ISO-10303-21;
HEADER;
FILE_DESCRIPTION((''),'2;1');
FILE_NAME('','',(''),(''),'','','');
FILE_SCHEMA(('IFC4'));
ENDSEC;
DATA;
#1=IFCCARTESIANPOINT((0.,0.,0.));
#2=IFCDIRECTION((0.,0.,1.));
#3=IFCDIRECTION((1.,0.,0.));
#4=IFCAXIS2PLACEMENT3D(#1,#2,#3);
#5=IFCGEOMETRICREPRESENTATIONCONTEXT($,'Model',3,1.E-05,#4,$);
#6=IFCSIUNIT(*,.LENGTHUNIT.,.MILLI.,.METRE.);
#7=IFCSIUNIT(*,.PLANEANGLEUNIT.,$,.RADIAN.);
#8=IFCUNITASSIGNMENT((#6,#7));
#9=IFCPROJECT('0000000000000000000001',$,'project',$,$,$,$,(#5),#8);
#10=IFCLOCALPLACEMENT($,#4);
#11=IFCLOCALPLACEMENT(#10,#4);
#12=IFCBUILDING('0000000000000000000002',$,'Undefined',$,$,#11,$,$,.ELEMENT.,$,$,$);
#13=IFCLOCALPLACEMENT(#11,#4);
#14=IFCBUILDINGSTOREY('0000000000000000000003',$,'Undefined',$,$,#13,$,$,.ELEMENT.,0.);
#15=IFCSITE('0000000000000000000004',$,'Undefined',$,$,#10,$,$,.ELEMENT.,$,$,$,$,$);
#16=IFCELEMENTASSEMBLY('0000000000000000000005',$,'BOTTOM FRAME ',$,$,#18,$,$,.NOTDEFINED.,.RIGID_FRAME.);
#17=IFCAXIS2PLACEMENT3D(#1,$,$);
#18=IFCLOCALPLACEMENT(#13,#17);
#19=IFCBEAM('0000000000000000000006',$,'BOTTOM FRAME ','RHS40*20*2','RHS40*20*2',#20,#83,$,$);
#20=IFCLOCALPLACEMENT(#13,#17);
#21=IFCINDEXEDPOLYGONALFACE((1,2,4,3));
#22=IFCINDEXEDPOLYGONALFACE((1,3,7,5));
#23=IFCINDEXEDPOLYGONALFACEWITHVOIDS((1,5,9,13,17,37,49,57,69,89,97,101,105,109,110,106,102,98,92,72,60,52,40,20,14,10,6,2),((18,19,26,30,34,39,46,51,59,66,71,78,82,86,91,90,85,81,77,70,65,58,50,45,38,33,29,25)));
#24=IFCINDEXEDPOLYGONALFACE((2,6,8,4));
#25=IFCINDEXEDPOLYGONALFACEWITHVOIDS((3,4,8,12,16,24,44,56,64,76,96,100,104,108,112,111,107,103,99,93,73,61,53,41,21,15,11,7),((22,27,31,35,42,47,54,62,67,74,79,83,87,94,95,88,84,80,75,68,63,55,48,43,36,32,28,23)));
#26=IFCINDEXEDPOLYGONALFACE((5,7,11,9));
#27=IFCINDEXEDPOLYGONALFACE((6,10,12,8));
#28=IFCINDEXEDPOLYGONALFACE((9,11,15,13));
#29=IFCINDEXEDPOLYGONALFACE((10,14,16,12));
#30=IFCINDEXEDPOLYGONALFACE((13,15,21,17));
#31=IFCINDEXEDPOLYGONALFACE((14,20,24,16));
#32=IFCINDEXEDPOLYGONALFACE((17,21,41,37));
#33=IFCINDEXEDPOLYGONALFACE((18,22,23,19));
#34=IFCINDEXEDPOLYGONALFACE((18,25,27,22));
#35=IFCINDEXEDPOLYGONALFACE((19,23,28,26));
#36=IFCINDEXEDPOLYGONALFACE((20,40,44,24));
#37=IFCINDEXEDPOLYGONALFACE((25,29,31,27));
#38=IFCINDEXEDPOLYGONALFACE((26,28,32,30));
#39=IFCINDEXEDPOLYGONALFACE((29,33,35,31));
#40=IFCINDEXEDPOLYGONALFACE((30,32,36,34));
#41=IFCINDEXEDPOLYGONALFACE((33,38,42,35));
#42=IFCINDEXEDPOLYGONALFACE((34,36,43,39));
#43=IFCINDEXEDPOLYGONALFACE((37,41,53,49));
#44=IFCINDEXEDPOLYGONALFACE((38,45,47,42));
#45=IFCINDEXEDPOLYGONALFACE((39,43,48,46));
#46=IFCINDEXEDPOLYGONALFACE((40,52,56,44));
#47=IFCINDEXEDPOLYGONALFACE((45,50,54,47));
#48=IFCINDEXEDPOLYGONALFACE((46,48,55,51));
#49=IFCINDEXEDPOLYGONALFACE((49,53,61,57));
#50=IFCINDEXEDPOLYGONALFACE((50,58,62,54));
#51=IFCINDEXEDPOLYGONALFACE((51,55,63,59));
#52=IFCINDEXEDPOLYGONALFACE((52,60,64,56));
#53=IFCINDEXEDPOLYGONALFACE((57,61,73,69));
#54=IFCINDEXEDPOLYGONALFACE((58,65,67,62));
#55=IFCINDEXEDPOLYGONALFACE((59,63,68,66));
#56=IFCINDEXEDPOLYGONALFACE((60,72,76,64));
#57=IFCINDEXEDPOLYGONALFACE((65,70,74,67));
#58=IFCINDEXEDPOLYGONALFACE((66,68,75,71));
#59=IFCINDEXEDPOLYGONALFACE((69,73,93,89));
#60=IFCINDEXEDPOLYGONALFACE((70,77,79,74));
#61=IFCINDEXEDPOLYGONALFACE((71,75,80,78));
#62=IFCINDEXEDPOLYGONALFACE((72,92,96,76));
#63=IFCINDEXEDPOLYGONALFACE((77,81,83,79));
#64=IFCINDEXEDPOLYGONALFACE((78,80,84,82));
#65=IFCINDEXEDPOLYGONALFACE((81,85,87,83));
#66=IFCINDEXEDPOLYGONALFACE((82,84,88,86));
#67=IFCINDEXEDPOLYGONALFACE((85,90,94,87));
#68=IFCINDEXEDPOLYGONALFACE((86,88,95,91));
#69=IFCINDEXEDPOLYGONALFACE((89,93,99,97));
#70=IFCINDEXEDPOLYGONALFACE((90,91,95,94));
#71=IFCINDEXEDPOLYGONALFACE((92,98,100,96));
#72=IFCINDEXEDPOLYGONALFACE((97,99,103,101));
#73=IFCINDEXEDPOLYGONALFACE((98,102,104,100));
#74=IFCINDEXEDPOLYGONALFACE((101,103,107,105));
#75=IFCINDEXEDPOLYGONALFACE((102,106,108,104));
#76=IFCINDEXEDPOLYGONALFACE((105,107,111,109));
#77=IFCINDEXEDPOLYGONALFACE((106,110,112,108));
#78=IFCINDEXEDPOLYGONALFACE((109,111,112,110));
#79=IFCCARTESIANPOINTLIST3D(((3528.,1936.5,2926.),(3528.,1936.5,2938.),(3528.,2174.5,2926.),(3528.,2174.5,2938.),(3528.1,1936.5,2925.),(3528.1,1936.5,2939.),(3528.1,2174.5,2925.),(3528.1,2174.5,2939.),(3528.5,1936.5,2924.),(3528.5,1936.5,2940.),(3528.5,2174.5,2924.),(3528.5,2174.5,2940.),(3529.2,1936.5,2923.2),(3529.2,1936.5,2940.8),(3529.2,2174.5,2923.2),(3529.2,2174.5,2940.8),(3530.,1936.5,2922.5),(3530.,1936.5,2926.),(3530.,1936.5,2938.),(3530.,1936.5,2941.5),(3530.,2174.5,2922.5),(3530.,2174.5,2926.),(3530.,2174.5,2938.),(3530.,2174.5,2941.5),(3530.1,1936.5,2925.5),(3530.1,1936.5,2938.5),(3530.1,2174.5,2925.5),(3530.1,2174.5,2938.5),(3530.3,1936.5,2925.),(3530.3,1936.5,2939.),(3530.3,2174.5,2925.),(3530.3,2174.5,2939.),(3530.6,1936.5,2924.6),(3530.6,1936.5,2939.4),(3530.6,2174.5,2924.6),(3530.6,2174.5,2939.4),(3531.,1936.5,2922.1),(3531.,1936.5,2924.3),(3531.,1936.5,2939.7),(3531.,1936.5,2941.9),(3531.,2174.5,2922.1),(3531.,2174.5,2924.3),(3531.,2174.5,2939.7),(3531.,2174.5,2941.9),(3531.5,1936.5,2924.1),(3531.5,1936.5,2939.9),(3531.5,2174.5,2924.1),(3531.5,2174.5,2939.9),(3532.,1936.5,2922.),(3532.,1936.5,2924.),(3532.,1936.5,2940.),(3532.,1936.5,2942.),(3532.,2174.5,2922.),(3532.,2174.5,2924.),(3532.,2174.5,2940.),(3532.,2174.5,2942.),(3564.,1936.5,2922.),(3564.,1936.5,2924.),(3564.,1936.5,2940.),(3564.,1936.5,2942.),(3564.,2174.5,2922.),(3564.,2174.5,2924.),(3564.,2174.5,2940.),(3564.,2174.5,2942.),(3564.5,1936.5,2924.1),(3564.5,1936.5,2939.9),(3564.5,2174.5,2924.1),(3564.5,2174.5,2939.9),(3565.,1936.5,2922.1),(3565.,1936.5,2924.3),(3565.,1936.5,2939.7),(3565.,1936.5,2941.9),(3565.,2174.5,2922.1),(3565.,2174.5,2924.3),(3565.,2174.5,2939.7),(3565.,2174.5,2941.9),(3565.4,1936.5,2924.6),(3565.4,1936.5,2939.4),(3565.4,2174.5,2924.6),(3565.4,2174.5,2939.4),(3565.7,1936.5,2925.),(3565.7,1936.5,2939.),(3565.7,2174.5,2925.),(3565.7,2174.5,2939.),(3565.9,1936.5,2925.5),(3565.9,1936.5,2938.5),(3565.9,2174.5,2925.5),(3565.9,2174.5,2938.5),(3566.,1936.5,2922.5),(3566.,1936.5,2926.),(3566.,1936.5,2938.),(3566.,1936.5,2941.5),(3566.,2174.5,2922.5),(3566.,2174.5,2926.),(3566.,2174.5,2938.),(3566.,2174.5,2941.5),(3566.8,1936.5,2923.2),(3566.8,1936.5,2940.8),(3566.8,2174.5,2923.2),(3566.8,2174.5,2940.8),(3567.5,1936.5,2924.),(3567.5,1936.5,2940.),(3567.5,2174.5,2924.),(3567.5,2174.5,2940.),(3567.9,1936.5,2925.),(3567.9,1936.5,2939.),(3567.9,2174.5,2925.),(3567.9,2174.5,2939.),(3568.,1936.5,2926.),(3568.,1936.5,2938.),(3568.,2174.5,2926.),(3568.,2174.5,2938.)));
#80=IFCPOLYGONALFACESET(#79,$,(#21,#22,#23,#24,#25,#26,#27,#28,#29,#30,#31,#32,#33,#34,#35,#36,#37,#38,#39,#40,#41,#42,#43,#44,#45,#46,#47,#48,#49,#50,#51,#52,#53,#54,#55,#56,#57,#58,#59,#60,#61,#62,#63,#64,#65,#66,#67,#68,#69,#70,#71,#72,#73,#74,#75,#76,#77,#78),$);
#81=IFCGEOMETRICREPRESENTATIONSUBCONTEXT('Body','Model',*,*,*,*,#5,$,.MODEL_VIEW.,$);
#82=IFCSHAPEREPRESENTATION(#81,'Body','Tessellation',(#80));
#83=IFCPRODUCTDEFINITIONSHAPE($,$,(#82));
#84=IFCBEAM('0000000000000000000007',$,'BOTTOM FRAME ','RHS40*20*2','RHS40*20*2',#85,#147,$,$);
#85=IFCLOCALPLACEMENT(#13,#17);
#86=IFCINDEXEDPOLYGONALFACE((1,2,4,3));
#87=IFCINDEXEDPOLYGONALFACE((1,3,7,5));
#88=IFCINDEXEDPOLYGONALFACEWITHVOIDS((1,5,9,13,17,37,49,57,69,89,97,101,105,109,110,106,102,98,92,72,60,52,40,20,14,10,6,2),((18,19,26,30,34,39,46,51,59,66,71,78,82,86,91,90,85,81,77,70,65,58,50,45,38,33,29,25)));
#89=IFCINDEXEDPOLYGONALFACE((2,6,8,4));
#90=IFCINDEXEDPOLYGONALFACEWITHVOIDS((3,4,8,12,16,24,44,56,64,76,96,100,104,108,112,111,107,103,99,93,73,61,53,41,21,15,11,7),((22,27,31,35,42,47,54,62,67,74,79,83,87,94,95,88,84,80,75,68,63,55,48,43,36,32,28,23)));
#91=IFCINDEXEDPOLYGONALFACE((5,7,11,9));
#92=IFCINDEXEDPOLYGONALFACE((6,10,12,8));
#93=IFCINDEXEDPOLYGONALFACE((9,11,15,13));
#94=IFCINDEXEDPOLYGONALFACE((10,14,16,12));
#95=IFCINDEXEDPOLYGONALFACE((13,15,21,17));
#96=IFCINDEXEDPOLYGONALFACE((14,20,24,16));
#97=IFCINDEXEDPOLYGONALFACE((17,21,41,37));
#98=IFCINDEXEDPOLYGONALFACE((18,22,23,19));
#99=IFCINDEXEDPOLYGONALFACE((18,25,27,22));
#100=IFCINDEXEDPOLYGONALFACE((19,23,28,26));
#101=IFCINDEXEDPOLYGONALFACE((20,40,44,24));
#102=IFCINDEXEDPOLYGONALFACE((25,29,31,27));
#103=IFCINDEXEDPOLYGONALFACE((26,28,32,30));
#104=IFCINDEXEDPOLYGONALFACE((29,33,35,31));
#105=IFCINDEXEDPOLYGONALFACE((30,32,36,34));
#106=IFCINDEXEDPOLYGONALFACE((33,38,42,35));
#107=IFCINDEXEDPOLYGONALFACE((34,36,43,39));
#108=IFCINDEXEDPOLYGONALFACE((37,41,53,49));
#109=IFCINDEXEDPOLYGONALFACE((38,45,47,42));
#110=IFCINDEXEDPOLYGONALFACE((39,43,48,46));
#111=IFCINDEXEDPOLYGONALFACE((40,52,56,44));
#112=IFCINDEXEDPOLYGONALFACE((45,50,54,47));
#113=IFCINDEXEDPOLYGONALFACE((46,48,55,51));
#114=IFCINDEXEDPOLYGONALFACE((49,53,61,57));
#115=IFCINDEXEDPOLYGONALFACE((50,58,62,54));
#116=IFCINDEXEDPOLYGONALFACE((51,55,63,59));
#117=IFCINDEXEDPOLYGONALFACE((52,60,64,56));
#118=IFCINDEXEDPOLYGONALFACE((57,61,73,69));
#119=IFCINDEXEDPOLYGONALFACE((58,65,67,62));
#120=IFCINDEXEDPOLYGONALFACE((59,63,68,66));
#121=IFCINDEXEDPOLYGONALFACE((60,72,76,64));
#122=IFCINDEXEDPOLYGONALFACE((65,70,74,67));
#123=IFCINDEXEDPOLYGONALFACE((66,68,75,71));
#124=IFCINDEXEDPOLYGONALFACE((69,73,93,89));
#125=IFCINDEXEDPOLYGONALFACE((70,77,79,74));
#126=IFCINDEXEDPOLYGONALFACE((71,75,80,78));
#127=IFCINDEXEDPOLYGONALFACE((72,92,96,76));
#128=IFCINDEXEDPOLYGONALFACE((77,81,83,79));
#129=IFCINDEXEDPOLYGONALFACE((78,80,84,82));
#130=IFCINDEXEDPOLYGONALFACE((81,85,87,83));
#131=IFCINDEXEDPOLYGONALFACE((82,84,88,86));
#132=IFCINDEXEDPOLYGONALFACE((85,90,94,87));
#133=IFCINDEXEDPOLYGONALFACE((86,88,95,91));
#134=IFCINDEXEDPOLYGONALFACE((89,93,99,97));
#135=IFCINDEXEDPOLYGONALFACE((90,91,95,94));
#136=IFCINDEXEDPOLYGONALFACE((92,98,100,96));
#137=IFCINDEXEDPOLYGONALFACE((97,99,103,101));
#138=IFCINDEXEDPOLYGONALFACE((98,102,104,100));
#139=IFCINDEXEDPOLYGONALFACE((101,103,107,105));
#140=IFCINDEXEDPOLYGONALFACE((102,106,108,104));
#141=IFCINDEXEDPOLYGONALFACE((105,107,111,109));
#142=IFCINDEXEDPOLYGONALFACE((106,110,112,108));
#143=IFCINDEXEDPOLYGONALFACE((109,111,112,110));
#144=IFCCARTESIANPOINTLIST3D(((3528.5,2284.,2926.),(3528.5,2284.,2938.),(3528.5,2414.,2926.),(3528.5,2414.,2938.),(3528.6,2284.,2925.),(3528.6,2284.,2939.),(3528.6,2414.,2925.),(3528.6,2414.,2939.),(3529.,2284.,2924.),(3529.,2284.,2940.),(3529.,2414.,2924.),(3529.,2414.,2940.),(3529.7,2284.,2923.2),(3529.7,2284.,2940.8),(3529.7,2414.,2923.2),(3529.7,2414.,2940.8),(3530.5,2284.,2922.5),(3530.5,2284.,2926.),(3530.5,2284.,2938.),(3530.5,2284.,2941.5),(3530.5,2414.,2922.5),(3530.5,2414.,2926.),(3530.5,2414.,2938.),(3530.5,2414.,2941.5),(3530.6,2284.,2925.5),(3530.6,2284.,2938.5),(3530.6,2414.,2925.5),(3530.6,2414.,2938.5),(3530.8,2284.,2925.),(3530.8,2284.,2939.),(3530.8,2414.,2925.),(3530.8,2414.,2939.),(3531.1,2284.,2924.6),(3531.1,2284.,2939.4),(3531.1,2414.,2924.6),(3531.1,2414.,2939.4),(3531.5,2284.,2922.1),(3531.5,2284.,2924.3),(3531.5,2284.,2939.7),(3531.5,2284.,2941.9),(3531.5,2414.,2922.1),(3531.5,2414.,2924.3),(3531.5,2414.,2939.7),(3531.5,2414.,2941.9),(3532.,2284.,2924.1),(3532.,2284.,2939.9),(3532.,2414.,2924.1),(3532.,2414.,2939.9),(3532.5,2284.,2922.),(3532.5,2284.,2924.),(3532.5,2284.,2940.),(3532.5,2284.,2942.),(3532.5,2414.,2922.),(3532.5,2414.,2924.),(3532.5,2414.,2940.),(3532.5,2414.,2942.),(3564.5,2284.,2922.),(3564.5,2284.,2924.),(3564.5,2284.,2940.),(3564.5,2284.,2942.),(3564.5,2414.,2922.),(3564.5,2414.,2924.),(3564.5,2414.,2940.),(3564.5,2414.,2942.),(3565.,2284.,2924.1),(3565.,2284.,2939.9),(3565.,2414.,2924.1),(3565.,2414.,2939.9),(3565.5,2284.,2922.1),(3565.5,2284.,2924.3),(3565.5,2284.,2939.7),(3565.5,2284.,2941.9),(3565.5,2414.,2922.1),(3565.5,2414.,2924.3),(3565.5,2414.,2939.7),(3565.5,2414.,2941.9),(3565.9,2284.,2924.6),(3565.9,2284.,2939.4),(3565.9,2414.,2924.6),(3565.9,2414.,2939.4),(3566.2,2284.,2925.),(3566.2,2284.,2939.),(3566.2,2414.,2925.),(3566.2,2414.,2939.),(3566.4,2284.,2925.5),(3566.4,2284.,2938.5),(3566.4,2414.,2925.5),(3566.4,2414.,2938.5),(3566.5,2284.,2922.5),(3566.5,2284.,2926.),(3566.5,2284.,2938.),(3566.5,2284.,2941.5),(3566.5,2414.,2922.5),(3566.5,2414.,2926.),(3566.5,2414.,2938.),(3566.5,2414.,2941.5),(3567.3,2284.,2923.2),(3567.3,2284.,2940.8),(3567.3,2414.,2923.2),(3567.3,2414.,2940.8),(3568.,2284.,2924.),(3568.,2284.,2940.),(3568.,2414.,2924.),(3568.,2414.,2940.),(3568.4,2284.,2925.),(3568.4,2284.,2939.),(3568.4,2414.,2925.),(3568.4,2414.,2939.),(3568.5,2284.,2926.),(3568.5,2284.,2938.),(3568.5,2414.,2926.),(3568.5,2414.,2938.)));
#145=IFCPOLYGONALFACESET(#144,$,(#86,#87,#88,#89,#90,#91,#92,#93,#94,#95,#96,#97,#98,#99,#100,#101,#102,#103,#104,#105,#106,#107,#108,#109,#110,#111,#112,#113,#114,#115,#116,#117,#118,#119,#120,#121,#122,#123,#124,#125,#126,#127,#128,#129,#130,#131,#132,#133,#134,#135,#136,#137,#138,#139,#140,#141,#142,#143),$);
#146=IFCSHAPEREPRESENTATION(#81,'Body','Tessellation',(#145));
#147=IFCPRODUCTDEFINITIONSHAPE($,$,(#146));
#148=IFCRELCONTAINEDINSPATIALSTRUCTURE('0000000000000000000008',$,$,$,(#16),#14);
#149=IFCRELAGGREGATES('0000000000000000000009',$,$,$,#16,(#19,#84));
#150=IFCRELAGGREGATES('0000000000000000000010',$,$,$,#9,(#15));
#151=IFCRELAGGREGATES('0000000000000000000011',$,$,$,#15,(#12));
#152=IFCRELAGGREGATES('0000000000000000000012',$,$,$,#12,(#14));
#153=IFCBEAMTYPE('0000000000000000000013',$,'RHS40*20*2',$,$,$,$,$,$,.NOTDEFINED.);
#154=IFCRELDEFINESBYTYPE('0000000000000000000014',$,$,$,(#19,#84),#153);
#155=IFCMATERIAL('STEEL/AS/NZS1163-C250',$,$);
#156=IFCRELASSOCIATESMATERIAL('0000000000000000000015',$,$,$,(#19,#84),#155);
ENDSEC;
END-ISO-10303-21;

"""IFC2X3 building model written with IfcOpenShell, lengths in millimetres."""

from ifc_helpers import new_model, si_unit, frame, origin_with_axes, origin_2d_with_axis, place, context, subcontext, project, spatial, hollow_rectangle, extrude, material, type_object, element, aggregate, save


model = new_model("IFC2X3")

# Units and contexts
model_context = context("Model", 3, precision=1e-05, world=origin_with_axes())
body_context = subcontext(model_context, "Body", "Model", "MODEL_VIEW")
ifc_project = project(units=[si_unit("LENGTHUNIT", "METRE", prefix="MILLI"), si_unit("PLANEANGLEUNIT", "RADIAN")], contexts=[model_context])

# Site, building, storey
site_placement = place(None, origin_with_axes())
site = spatial("IfcSite", under=ifc_project, at=site_placement, Name="Undefined", CompositionType="ELEMENT")
building_placement = place(site_placement, origin_with_axes())
building = spatial("IfcBuilding", under=site, at=building_placement, Name="Undefined", CompositionType="ELEMENT")
storey_placement = place(building_placement, origin_with_axes())
storey = spatial("IfcBuildingStorey", under=building, at=storey_placement, Name="Undefined", CompositionType="ELEMENT", Elevation=0.0)

# Element assembly, beams
assembly_1_placement = place(storey_placement, origin_with_axes())
assembly_1 = element("IfcElementAssembly", 1, at=assembly_1_placement, inside=storey, Name="BOTTOM FRAME ", AssemblyPlace="NOTDEFINED", PredefinedType="RIGID_FRAME")
ifc_material_1 = material(Name="STEEL/AS/NZS1163-C250")
beam_type_1 = type_object("IfcBeamType", Name="RHS40*20*2", PredefinedType="NOTDEFINED")
beam_1_placement = place(assembly_1_placement, frame((3548.0, 2174.5, 2932.0), z_axis=(1.0, 0.0, 0.0), x_axis=(0.0, -1.0, 0.0)))
beam_1 = element("IfcBeam", 2, at=beam_1_placement, type_object=beam_type_1, material=ifc_material_1, Name="BOTTOM FRAME ", Description="RHS40*20*2", ObjectType="RHS40*20*2", context=body_context, shape_type="SweptSolid", body=[
    extrude(hollow_rectangle(XDim=20.0, YDim=40.0, WallThickness=2.0, InnerFilletRadius=2.0, OuterFilletRadius=4.0, at=origin_2d_with_axis()), frame((238.0, 0.0, 0.0), z_axis=(-1.0, 0.0, 0.0), x_axis=(0.0, -1.0, 0.0)), (0.0, 0.0, 1.0), 238.0),
])
beam_2_placement = place(assembly_1_placement, frame((3548.5, 2414.0, 2932.0), z_axis=(1.0, 0.0, 0.0), x_axis=(0.0, -1.0, 0.0)))
beam_2 = element("IfcBeam", 3, at=beam_2_placement, type_object=beam_type_1, material=ifc_material_1, Name="BOTTOM FRAME ", Description="RHS40*20*2", ObjectType="RHS40*20*2", context=body_context, shape_type="SweptSolid", body=[
    extrude(hollow_rectangle(XDim=20.0, YDim=40.0, WallThickness=2.0, InnerFilletRadius=2.0, OuterFilletRadius=4.0, at=origin_2d_with_axis()), frame((130.0, 0.0, 0.0), z_axis=(-1.0, 0.0, 0.0), x_axis=(0.0, -1.0, 0.0)), (0.0, 0.0, 1.0), 130.0),
])

aggregate(assembly_1, [beam_1, beam_2])

save(model, "model.ifc")
